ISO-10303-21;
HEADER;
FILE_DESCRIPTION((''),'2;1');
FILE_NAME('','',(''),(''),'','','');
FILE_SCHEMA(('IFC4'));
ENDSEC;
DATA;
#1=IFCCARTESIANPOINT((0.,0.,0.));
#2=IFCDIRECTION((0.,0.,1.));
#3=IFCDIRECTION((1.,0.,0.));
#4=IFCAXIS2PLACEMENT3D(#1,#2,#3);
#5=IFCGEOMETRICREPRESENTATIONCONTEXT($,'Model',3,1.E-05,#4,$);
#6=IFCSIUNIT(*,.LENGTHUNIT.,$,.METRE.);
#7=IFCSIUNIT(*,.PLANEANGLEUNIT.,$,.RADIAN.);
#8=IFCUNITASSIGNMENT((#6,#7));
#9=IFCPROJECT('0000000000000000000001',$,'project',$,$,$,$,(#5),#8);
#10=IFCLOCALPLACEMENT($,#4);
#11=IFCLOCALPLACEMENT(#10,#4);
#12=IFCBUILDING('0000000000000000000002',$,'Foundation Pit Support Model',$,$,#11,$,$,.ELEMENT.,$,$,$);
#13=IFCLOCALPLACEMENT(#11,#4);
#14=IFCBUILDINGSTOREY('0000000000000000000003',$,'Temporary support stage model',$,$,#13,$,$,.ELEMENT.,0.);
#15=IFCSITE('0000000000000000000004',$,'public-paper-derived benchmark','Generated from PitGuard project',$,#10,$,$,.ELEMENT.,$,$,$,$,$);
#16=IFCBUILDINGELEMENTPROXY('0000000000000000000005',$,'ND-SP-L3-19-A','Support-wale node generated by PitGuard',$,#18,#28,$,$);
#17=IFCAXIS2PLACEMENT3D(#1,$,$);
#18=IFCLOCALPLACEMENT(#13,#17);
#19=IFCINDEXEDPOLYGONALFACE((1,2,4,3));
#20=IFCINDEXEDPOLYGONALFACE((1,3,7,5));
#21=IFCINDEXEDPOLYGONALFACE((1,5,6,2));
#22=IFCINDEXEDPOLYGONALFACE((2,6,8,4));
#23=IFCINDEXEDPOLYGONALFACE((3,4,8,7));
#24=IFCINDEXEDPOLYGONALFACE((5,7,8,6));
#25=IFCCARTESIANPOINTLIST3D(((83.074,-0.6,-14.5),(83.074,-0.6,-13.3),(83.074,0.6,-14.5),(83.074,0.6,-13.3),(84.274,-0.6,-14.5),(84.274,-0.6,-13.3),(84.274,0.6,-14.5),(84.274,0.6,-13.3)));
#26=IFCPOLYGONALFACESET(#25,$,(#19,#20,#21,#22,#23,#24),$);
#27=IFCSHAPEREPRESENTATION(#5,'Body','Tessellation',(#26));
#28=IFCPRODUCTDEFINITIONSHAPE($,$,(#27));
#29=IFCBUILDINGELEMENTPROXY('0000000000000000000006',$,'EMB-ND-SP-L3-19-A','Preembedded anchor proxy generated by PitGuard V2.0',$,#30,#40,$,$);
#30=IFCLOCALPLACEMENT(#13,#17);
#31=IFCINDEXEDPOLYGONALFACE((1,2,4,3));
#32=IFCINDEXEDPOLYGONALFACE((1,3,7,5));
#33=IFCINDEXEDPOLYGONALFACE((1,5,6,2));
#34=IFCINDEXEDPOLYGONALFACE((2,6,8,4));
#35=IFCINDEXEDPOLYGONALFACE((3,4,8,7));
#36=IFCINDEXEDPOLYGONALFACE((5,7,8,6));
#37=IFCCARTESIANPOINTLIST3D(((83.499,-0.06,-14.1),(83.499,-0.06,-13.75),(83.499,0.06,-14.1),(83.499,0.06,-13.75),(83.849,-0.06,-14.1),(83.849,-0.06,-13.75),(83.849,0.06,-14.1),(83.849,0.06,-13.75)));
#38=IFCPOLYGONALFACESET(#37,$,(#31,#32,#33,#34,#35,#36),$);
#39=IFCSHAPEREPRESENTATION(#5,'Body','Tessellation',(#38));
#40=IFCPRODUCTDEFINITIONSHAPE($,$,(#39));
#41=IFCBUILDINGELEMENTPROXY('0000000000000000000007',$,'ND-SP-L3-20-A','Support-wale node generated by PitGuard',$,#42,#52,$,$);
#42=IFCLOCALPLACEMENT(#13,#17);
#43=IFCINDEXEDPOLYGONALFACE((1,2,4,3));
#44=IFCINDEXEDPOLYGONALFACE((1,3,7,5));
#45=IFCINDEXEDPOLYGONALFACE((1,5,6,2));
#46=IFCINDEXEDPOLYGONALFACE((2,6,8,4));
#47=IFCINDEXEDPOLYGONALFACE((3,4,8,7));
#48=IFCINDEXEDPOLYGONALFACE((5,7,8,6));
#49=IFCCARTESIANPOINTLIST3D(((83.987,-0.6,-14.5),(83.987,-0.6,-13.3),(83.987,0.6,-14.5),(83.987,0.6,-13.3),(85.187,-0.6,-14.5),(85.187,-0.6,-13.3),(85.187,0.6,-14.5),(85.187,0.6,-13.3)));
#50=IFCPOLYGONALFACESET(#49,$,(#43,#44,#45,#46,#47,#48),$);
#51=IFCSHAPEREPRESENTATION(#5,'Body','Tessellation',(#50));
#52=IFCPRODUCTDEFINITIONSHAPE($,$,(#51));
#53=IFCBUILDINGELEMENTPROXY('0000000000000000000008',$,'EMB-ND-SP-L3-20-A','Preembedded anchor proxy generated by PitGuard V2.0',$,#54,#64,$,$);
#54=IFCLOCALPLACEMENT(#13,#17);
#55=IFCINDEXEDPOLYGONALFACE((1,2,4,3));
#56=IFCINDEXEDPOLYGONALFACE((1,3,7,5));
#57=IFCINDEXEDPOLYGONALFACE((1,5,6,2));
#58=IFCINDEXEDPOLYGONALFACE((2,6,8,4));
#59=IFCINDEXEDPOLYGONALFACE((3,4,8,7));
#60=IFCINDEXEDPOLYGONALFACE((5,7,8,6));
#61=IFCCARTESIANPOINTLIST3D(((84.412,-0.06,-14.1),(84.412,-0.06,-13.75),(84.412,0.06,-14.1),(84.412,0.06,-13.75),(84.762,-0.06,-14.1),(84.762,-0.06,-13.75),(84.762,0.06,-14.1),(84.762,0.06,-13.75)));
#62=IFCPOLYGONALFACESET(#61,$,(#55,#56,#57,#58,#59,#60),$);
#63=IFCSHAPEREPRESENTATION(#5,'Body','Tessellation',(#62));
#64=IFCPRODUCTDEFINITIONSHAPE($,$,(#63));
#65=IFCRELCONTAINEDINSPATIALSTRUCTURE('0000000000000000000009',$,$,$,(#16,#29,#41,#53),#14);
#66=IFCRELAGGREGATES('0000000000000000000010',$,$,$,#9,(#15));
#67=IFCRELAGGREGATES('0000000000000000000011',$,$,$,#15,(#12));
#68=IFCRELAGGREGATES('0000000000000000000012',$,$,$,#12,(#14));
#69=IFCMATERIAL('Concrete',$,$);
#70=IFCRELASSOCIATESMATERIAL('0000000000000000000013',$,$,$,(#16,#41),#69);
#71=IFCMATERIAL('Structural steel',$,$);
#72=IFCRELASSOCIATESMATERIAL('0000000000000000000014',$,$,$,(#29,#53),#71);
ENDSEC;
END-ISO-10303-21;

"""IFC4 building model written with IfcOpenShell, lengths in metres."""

from ifc_helpers import new_model, si_unit, frame, origin_with_axes, origin_2d, place, context, project, spatial, rectangle, extrude, material, element, save


model = new_model("IFC4")

# Units and contexts
model_context = context("Model", 3, precision=1e-05, world=origin_with_axes())
ifc_project = project(units=[si_unit("LENGTHUNIT", "METRE"), si_unit("PLANEANGLEUNIT", "RADIAN")], contexts=[model_context])

# Site, building, storey
site_placement = place(None, origin_with_axes())
site = spatial("IfcSite", under=ifc_project, at=site_placement, Name="public-paper-derived benchmark", Description="Generated from PitGuard project", CompositionType="ELEMENT")
building_placement = place(site_placement, origin_with_axes())
building = spatial("IfcBuilding", under=site, at=building_placement, Name="Foundation Pit Support Model", CompositionType="ELEMENT")
storey_placement = place(building_placement, origin_with_axes())
storey = spatial("IfcBuildingStorey", under=building, at=storey_placement, Name="Temporary support stage model", CompositionType="ELEMENT", Elevation=0.0)

# Shared definitions
ifc_material_1 = material(Name="Structural steel")

# Shared definitions
ifc_material_2 = material(Name="Concrete")

# Building element proxies
proxy_1_placement = place(storey_placement, frame((83.674, 0.0, -14.5), z_axis=(0.0, 0.0, 1.0), x_axis=(1.0, 0.0, 0.0)))
element("IfcBuildingElementProxy", 1, at=proxy_1_placement, inside=storey, material=ifc_material_2, Name="ND-SP-L3-19-A", Description="Support-wale node generated by PitGuard", context=model_context, shape_type="SweptSolid", body=[
    extrude(rectangle(XDim=1.2, YDim=1.2, at=origin_2d()), origin_with_axes(), (0.0, 0.0, 1.0), 1.2),
])
proxy_2_placement = place(storey_placement, frame((83.674, 0.0, -14.1), z_axis=(0.0, 0.0, 1.0), x_axis=(1.0, 0.0, 0.0)))
element("IfcBuildingElementProxy", 2, at=proxy_2_placement, inside=storey, material=ifc_material_1, Name="EMB-ND-SP-L3-19-A", Description="Preembedded anchor proxy generated by PitGuard V2.0", context=model_context, shape_type="SweptSolid", body=[
    extrude(rectangle(XDim=0.35, YDim=0.12, at=origin_2d()), origin_with_axes(), (0.0, 0.0, 1.0), 0.35),
])
proxy_3_placement = place(storey_placement, frame((84.587, 0.0, -14.5), z_axis=(0.0, 0.0, 1.0), x_axis=(1.0, 0.0, 0.0)))
element("IfcBuildingElementProxy", 3, at=proxy_3_placement, inside=storey, material=ifc_material_2, Name="ND-SP-L3-20-A", Description="Support-wale node generated by PitGuard", context=model_context, shape_type="SweptSolid", body=[
    extrude(rectangle(XDim=1.2, YDim=1.2, at=origin_2d()), origin_with_axes(), (0.0, 0.0, 1.0), 1.2),
])
proxy_4_placement = place(storey_placement, frame((84.587, 0.0, -14.1), z_axis=(0.0, 0.0, 1.0), x_axis=(1.0, 0.0, 0.0)))
element("IfcBuildingElementProxy", 4, at=proxy_4_placement, inside=storey, material=ifc_material_1, Name="EMB-ND-SP-L3-20-A", Description="Preembedded anchor proxy generated by PitGuard V2.0", context=model_context, shape_type="SweptSolid", body=[
    extrude(rectangle(XDim=0.35, YDim=0.12, at=origin_2d()), origin_with_axes(), (0.0, 0.0, 1.0), 0.35),
])

save(model, "model.ifc")
